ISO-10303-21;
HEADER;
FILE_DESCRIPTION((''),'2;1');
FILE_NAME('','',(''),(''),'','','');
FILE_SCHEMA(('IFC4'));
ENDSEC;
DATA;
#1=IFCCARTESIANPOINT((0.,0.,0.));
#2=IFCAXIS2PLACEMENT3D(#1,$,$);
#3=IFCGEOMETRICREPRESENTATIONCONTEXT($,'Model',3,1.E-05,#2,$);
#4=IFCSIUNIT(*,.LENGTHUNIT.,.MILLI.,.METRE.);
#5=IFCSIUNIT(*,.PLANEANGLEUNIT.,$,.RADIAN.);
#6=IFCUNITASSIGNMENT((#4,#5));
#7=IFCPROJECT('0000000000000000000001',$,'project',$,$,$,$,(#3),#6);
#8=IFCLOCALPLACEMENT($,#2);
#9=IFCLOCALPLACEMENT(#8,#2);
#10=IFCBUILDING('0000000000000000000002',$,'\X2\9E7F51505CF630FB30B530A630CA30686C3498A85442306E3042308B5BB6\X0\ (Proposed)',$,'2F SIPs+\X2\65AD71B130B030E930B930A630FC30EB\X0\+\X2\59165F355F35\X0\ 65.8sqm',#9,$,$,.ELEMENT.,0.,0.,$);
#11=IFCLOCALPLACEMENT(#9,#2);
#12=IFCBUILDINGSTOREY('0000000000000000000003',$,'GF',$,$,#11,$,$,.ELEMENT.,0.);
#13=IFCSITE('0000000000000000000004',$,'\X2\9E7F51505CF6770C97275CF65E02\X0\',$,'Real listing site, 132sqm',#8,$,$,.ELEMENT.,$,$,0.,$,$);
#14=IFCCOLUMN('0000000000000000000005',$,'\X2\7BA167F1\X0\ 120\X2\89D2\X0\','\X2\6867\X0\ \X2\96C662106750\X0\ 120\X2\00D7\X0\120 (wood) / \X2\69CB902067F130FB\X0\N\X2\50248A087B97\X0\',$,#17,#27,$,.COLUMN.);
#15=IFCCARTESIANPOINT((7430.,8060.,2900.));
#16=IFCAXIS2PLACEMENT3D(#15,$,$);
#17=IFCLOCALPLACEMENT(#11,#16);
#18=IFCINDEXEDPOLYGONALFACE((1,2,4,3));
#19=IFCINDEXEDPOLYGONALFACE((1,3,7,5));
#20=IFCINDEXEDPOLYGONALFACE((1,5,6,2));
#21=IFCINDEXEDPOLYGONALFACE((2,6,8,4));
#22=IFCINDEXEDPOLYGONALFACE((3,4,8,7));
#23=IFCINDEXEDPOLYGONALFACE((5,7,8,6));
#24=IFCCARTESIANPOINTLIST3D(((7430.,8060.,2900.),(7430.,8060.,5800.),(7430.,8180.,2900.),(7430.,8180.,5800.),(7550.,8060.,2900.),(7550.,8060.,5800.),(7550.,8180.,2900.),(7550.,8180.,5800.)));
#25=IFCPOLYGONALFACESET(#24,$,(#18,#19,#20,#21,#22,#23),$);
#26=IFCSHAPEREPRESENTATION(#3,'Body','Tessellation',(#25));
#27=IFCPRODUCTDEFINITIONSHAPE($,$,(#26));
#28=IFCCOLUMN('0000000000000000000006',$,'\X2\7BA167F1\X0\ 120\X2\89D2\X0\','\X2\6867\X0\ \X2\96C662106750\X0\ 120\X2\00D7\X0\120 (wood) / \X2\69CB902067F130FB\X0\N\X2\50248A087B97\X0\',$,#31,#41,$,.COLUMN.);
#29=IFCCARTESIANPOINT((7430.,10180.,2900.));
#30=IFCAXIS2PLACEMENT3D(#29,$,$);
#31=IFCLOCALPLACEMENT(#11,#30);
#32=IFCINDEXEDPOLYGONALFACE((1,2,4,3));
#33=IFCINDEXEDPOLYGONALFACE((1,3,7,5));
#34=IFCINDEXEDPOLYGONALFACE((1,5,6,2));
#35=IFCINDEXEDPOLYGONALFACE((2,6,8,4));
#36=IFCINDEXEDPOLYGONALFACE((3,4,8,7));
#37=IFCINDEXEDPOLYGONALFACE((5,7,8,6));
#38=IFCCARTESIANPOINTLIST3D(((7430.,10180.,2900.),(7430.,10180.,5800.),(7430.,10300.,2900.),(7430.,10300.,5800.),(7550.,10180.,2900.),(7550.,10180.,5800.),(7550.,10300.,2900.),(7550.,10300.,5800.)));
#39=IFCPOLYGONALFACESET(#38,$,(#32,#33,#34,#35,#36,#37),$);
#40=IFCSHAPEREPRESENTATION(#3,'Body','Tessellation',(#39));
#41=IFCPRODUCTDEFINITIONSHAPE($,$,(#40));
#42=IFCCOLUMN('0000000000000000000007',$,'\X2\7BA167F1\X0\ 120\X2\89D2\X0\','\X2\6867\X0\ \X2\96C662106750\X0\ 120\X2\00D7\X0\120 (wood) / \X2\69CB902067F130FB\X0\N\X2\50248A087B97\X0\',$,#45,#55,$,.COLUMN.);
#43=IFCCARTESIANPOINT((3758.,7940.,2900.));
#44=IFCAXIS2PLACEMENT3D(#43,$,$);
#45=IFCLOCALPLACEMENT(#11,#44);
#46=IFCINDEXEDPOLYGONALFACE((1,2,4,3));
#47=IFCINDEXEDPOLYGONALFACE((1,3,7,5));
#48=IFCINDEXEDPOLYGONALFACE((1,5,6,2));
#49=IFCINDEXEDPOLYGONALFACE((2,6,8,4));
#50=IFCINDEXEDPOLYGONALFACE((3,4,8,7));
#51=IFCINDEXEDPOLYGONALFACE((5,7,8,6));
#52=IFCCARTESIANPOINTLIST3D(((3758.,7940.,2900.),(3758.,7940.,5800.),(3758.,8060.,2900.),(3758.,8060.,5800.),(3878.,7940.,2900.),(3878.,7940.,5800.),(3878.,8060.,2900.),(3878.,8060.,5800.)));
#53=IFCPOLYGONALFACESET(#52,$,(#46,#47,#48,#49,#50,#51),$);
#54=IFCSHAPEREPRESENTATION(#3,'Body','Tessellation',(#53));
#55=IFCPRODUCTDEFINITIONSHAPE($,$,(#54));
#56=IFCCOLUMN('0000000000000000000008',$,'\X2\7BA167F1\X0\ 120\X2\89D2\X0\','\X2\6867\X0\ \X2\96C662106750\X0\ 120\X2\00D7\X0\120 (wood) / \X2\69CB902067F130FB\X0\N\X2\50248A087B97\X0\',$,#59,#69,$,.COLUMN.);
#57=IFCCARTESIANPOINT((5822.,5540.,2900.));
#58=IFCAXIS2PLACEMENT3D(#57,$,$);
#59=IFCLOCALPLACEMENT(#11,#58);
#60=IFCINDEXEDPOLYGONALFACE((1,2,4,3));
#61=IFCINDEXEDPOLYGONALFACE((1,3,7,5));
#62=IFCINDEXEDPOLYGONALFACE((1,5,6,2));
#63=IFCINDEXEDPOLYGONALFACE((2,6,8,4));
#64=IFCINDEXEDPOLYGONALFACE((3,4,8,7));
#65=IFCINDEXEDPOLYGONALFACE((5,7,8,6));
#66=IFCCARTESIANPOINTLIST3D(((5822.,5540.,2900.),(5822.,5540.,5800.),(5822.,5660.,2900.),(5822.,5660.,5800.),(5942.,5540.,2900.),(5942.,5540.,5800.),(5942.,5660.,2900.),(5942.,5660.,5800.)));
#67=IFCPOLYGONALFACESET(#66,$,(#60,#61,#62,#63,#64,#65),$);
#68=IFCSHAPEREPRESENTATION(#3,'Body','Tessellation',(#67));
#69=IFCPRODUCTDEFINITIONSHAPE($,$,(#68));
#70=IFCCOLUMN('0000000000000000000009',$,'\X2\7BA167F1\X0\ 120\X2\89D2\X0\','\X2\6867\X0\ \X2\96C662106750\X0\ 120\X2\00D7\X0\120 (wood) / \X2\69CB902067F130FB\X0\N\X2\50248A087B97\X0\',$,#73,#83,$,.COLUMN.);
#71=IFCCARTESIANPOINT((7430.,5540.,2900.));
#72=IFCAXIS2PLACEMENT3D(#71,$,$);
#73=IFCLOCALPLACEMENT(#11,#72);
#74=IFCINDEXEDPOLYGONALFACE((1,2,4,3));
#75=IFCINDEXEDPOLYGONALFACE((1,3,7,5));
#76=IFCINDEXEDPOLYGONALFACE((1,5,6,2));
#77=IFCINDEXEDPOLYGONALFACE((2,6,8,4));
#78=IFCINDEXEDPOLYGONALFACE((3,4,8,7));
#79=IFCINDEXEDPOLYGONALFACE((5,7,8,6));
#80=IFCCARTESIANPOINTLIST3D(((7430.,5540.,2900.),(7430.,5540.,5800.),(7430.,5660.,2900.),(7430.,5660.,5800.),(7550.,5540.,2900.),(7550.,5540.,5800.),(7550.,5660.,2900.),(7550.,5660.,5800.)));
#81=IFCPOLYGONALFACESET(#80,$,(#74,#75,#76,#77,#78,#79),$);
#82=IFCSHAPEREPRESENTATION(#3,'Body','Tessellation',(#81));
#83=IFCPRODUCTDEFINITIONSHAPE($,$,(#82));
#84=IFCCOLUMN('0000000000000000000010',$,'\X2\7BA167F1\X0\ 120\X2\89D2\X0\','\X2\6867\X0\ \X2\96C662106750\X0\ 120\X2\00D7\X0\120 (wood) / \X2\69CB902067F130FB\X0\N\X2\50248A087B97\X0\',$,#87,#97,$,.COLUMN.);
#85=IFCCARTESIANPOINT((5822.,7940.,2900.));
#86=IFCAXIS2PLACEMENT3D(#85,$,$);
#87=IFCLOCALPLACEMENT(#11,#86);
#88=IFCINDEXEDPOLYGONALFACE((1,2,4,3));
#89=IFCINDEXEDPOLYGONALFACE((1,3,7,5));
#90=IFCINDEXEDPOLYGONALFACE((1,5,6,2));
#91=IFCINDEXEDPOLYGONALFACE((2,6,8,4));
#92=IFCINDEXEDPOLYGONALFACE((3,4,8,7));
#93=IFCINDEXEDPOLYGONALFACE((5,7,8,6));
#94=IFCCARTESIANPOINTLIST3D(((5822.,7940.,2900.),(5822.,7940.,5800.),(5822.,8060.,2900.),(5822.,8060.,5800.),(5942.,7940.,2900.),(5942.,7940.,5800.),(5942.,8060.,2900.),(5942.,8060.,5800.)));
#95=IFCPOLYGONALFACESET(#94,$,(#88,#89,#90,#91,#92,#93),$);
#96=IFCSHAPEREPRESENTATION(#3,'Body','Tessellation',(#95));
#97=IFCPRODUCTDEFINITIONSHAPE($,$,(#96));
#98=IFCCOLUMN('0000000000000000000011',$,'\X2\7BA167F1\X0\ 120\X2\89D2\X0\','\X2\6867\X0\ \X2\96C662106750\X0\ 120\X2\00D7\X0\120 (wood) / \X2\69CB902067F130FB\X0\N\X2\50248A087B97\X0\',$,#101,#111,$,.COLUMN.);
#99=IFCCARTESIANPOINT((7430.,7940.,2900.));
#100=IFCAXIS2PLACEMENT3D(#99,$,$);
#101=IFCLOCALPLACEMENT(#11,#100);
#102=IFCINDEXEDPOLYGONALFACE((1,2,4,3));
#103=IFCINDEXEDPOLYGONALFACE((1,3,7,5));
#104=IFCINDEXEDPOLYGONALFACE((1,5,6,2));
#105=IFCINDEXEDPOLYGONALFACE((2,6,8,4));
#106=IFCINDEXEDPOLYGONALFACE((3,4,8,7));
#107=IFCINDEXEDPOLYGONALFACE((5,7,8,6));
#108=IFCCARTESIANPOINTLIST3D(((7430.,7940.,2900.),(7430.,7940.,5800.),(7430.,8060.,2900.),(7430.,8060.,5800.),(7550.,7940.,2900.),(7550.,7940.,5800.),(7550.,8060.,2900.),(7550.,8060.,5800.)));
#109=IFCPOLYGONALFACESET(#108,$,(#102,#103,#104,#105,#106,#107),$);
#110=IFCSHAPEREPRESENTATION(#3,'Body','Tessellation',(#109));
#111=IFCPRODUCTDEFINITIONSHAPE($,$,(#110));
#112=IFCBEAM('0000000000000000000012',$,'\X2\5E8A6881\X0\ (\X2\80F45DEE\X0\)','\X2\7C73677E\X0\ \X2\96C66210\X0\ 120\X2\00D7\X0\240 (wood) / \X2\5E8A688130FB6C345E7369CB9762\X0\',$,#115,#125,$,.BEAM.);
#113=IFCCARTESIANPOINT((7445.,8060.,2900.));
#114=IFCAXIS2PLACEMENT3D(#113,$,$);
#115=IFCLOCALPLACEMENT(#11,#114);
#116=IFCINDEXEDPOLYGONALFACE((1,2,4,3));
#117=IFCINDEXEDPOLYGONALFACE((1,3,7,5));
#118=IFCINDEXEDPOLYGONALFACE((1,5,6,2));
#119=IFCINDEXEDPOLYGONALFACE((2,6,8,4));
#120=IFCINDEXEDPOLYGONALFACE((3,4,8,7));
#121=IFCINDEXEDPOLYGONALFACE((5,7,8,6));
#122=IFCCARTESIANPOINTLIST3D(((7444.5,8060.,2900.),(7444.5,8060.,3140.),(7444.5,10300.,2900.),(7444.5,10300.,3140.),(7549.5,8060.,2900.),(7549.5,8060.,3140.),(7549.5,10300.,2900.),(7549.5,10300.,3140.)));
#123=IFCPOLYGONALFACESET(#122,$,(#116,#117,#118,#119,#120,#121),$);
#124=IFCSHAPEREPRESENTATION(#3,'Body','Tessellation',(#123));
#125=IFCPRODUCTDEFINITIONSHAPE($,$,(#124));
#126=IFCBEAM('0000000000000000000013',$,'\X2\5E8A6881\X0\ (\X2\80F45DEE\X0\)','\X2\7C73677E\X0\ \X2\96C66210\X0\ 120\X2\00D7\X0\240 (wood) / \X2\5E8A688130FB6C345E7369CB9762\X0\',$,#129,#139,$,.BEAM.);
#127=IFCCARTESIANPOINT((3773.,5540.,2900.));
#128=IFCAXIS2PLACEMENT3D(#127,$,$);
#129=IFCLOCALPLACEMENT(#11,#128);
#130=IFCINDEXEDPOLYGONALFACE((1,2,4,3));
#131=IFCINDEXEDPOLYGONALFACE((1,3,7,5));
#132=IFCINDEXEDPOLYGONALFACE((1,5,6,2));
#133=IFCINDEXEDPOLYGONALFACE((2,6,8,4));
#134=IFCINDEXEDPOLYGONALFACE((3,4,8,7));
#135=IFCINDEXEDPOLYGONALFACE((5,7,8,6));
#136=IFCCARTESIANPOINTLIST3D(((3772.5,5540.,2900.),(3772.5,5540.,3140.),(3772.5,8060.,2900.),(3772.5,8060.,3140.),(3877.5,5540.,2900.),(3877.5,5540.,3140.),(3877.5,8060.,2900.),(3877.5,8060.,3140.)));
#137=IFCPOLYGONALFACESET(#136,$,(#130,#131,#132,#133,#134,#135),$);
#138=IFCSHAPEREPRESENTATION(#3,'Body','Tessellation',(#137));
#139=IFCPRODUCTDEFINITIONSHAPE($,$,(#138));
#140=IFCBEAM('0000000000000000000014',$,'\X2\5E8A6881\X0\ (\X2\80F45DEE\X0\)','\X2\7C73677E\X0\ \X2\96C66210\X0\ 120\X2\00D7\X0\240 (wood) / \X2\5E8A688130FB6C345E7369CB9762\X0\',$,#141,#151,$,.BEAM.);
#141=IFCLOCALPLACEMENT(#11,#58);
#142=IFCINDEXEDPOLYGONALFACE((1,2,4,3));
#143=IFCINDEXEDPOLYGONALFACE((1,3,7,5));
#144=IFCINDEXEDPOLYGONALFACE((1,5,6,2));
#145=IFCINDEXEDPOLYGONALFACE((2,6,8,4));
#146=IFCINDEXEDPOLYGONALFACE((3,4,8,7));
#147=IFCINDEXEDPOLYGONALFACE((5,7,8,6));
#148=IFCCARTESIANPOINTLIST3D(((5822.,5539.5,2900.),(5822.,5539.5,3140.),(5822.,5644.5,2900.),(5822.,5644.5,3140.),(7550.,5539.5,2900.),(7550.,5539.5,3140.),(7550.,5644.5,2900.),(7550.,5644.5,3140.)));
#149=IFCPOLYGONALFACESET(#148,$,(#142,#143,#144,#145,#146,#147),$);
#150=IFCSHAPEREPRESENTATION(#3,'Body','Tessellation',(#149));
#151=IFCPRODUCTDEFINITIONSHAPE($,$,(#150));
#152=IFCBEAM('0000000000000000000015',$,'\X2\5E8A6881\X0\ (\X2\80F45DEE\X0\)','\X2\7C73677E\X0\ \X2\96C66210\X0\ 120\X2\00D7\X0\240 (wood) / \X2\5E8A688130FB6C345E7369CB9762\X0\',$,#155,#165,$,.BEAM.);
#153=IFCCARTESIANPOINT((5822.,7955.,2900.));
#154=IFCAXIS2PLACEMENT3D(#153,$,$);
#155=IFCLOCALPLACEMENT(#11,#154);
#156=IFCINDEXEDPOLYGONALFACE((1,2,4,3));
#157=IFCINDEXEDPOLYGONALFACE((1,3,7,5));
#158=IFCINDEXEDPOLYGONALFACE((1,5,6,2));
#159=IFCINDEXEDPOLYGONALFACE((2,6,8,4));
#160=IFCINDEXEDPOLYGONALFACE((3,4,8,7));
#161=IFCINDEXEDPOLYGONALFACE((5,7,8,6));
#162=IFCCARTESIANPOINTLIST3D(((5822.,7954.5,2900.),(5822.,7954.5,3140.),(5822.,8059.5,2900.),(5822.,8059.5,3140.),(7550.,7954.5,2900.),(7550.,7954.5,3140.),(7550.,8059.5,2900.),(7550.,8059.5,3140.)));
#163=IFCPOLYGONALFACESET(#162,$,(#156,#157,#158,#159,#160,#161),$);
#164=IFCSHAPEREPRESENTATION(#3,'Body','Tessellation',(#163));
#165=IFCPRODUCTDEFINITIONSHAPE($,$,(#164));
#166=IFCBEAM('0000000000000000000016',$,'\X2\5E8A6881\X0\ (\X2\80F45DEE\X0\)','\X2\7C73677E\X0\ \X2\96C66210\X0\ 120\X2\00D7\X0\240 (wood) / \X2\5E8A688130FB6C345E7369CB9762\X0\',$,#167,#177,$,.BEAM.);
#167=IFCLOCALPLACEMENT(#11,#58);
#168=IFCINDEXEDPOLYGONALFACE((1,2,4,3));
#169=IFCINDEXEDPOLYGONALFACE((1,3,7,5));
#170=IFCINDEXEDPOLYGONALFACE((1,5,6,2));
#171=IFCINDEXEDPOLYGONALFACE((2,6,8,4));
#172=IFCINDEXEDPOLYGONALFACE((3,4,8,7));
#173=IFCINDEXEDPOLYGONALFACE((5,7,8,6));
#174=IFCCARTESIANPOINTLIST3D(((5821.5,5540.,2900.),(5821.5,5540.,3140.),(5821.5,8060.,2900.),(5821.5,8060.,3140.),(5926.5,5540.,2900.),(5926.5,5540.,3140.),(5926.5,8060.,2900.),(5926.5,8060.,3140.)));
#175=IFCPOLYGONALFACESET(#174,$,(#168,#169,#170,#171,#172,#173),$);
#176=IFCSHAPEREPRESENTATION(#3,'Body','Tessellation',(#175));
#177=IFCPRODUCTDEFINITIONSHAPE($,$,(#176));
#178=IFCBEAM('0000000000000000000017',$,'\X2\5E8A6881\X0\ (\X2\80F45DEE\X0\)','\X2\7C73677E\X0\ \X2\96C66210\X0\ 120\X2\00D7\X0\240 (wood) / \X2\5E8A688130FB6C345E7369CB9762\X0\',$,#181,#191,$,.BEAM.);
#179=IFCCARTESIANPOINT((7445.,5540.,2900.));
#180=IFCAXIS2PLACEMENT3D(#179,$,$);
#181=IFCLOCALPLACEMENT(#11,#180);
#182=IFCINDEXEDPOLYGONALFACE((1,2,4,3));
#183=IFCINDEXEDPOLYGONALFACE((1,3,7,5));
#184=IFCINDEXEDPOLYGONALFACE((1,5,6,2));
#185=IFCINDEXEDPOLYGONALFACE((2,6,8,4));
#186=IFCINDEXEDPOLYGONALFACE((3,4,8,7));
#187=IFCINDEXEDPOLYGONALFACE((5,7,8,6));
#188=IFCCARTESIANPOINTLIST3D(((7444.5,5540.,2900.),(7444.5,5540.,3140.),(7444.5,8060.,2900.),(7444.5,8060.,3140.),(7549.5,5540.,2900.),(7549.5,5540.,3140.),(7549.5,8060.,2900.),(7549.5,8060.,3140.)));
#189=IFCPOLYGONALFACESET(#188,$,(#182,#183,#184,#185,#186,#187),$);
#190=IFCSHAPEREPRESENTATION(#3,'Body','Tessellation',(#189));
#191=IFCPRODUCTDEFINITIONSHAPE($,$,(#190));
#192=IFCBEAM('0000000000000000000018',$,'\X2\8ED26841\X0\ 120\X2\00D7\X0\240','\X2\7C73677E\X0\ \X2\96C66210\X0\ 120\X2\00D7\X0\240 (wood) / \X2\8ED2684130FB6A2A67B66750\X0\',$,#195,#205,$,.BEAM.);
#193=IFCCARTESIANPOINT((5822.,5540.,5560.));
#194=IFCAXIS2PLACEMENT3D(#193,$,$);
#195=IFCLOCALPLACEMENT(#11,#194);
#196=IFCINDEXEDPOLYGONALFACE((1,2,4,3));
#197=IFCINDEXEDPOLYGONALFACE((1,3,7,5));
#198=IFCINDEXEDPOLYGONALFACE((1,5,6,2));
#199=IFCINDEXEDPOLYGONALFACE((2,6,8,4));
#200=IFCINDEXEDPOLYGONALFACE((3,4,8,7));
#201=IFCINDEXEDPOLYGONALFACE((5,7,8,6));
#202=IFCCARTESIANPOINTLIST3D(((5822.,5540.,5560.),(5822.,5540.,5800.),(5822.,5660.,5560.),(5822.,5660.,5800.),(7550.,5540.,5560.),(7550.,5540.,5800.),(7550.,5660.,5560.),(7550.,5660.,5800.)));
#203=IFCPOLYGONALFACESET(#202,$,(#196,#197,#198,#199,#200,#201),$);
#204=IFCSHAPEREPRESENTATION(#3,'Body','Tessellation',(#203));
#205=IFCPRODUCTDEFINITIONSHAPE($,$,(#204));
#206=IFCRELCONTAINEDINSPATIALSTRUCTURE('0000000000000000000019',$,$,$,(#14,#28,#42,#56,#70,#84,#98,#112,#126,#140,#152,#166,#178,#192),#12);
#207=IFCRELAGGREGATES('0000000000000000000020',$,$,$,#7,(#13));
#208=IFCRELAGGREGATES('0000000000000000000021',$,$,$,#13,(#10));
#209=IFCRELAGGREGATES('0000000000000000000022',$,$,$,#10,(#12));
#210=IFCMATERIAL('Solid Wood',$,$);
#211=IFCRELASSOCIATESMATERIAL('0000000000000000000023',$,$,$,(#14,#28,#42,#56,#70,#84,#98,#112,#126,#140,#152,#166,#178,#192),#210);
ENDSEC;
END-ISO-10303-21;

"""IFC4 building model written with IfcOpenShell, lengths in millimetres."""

from ifc_helpers import new_model, si_unit, frame, frame_2d, origin, place, context, project, spatial, rectangle, extrude, material, element, save


model = new_model("IFC4")

# Units and contexts
model_context = context("Model", 3, precision=1e-05, world=origin())
ifc_project = project(units=[si_unit("LENGTHUNIT", "METRE", prefix="MILLI"), si_unit("PLANEANGLEUNIT", "RADIAN")], contexts=[model_context])

# Site, building, storey
site_placement = place(None, origin())
site = spatial("IfcSite", under=ifc_project, at=site_placement, Name="鹿児島県霧島市", ObjectType="Real listing site, 132sqm", CompositionType="ELEMENT", RefElevation=0.0)
building_placement = place(site_placement, origin())
building = spatial("IfcBuilding", under=site, at=building_placement, Name="鹿児島・サウナと水風呂のある家 (Proposed)", ObjectType="2F SIPs+断熱グラスウール+外張張 65.8sqm", CompositionType="ELEMENT", ElevationOfRefHeight=0.0, ElevationOfTerrain=0.0)
storey_placement = place(building_placement, origin())
storey = spatial("IfcBuildingStorey", under=building, at=storey_placement, Name="GF", CompositionType="ELEMENT", Elevation=0.0)

# Columns
ifc_material_1 = material(Name="Solid Wood")
column_1_placement = place(storey_placement, frame((7430.0, 8060.0, 2900.0)))
element("IfcColumn", 1, at=column_1_placement, inside=storey, material=ifc_material_1, Name="管柱 120角", Description="桧 集成材 120×120 (wood) / 構造柱・N値計算", PredefinedType="COLUMN", context=model_context, shape_type="SweptSolid", body=[
    extrude(rectangle(XDim=120.0, YDim=120.0, at=frame_2d((60.0, 60.0))), frame((7430.0, 8060.0, 2900.0)), (0.0, 0.0, 1.0), 2900.0),
])
column_2_placement = place(storey_placement, frame((7430.0, 10180.0, 2900.0)))
element("IfcColumn", 2, at=column_2_placement, inside=storey, material=ifc_material_1, Name="管柱 120角", Description="桧 集成材 120×120 (wood) / 構造柱・N値計算", PredefinedType="COLUMN", context=model_context, shape_type="SweptSolid", body=[
    extrude(rectangle(XDim=120.0, YDim=120.0, at=frame_2d((60.0, 60.0))), frame((7430.0, 10180.0, 2900.0)), (0.0, 0.0, 1.0), 2900.0),
])
column_3_placement = place(storey_placement, frame((3758.0, 7940.0, 2900.0)))
element("IfcColumn", 3, at=column_3_placement, inside=storey, material=ifc_material_1, Name="管柱 120角", Description="桧 集成材 120×120 (wood) / 構造柱・N値計算", PredefinedType="COLUMN", context=model_context, shape_type="SweptSolid", body=[
    extrude(rectangle(XDim=120.0, YDim=120.0, at=frame_2d((60.0, 60.0))), frame((3758.0, 7940.0, 2900.0)), (0.0, 0.0, 1.0), 2900.0),
])
column_4_placement = place(storey_placement, frame((5822.0, 5540.0, 2900.0)))
element("IfcColumn", 4, at=column_4_placement, inside=storey, material=ifc_material_1, Name="管柱 120角", Description="桧 集成材 120×120 (wood) / 構造柱・N値計算", PredefinedType="COLUMN", context=model_context, shape_type="SweptSolid", body=[
    extrude(rectangle(XDim=120.0, YDim=120.0, at=frame_2d((60.0, 60.0))), frame((5822.0, 5540.0, 2900.0)), (0.0, 0.0, 1.0), 2900.0),
])
column_5_placement = place(storey_placement, frame((7430.0, 5540.0, 2900.0)))
element("IfcColumn", 5, at=column_5_placement, inside=storey, material=ifc_material_1, Name="管柱 120角", Description="桧 集成材 120×120 (wood) / 構造柱・N値計算", PredefinedType="COLUMN", context=model_context, shape_type="SweptSolid", body=[
    extrude(rectangle(XDim=120.0, YDim=120.0, at=frame_2d((60.0, 60.0))), frame((7430.0, 5540.0, 2900.0)), (0.0, 0.0, 1.0), 2900.0),
])
column_6_placement = place(storey_placement, frame((5822.0, 7940.0, 2900.0)))
element("IfcColumn", 6, at=column_6_placement, inside=storey, material=ifc_material_1, Name="管柱 120角", Description="桧 集成材 120×120 (wood) / 構造柱・N値計算", PredefinedType="COLUMN", context=model_context, shape_type="SweptSolid", body=[
    extrude(rectangle(XDim=120.0, YDim=120.0, at=frame_2d((60.0, 60.0))), frame((5822.0, 7940.0, 2900.0)), (0.0, 0.0, 1.0), 2900.0),
])
column_7_placement = place(storey_placement, frame((7430.0, 7940.0, 2900.0)))
element("IfcColumn", 7, at=column_7_placement, inside=storey, material=ifc_material_1, Name="管柱 120角", Description="桧 集成材 120×120 (wood) / 構造柱・N値計算", PredefinedType="COLUMN", context=model_context, shape_type="SweptSolid", body=[
    extrude(rectangle(XDim=120.0, YDim=120.0, at=frame_2d((60.0, 60.0))), frame((7430.0, 7940.0, 2900.0)), (0.0, 0.0, 1.0), 2900.0),
])

# Beams
beam_1_placement = place(storey_placement, frame((7445.0, 8060.0, 2900.0)))
element("IfcBeam", 8, at=beam_1_placement, inside=storey, material=ifc_material_1, Name="床梁 (胴差)", Description="米松 集成 120×240 (wood) / 床梁・水平構面", PredefinedType="BEAM", context=model_context, shape_type="SweptSolid", body=[
    extrude(rectangle(XDim=105.0, YDim=2240.0, at=frame_2d((52.0, 1120.0))), frame((7445.0, 8060.0, 2900.0)), (0.0, 0.0, 1.0), 240.0),
])
beam_2_placement = place(storey_placement, frame((3773.0, 5540.0, 2900.0)))
element("IfcBeam", 9, at=beam_2_placement, inside=storey, material=ifc_material_1, Name="床梁 (胴差)", Description="米松 集成 120×240 (wood) / 床梁・水平構面", PredefinedType="BEAM", context=model_context, shape_type="SweptSolid", body=[
    extrude(rectangle(XDim=105.0, YDim=2520.0, at=frame_2d((52.0, 1260.0))), frame((3773.0, 5540.0, 2900.0)), (0.0, 0.0, 1.0), 240.0),
])
beam_3_placement = place(storey_placement, frame((5822.0, 5540.0, 2900.0)))
element("IfcBeam", 10, at=beam_3_placement, inside=storey, material=ifc_material_1, Name="床梁 (胴差)", Description="米松 集成 120×240 (wood) / 床梁・水平構面", PredefinedType="BEAM", context=model_context, shape_type="SweptSolid", body=[
    extrude(rectangle(XDim=1728.0, YDim=105.0, at=frame_2d((864.0, 52.0))), frame((5822.0, 5540.0, 2900.0)), (0.0, 0.0, 1.0), 240.0),
])
beam_4_placement = place(storey_placement, frame((5822.0, 7955.0, 2900.0)))
element("IfcBeam", 11, at=beam_4_placement, inside=storey, material=ifc_material_1, Name="床梁 (胴差)", Description="米松 集成 120×240 (wood) / 床梁・水平構面", PredefinedType="BEAM", context=model_context, shape_type="SweptSolid", body=[
    extrude(rectangle(XDim=1728.0, YDim=105.0, at=frame_2d((864.0, 52.0))), frame((5822.0, 7955.0, 2900.0)), (0.0, 0.0, 1.0), 240.0),
])
beam_5_placement = place(storey_placement, frame((5822.0, 5540.0, 2900.0)))
element("IfcBeam", 12, at=beam_5_placement, inside=storey, material=ifc_material_1, Name="床梁 (胴差)", Description="米松 集成 120×240 (wood) / 床梁・水平構面", PredefinedType="BEAM", context=model_context, shape_type="SweptSolid", body=[
    extrude(rectangle(XDim=105.0, YDim=2520.0, at=frame_2d((52.0, 1260.0))), frame((5822.0, 5540.0, 2900.0)), (0.0, 0.0, 1.0), 240.0),
])
beam_6_placement = place(storey_placement, frame((7445.0, 5540.0, 2900.0)))
element("IfcBeam", 13, at=beam_6_placement, inside=storey, material=ifc_material_1, Name="床梁 (胴差)", Description="米松 集成 120×240 (wood) / 床梁・水平構面", PredefinedType="BEAM", context=model_context, shape_type="SweptSolid", body=[
    extrude(rectangle(XDim=105.0, YDim=2520.0, at=frame_2d((52.0, 1260.0))), frame((7445.0, 5540.0, 2900.0)), (0.0, 0.0, 1.0), 240.0),
])
beam_7_placement = place(storey_placement, frame((5822.0, 5540.0, 5560.0)))
element("IfcBeam", 14, at=beam_7_placement, inside=storey, material=ifc_material_1, Name="軒桁 120×240", Description="米松 集成 120×240 (wood) / 軒桁・横架材", PredefinedType="BEAM", context=model_context, shape_type="SweptSolid", body=[
    extrude(rectangle(XDim=1728.0, YDim=120.0, at=frame_2d((864.0, 60.0))), frame((5822.0, 5540.0, 5560.0)), (0.0, 0.0, 1.0), 240.0),
])

save(model, "model.ifc")
